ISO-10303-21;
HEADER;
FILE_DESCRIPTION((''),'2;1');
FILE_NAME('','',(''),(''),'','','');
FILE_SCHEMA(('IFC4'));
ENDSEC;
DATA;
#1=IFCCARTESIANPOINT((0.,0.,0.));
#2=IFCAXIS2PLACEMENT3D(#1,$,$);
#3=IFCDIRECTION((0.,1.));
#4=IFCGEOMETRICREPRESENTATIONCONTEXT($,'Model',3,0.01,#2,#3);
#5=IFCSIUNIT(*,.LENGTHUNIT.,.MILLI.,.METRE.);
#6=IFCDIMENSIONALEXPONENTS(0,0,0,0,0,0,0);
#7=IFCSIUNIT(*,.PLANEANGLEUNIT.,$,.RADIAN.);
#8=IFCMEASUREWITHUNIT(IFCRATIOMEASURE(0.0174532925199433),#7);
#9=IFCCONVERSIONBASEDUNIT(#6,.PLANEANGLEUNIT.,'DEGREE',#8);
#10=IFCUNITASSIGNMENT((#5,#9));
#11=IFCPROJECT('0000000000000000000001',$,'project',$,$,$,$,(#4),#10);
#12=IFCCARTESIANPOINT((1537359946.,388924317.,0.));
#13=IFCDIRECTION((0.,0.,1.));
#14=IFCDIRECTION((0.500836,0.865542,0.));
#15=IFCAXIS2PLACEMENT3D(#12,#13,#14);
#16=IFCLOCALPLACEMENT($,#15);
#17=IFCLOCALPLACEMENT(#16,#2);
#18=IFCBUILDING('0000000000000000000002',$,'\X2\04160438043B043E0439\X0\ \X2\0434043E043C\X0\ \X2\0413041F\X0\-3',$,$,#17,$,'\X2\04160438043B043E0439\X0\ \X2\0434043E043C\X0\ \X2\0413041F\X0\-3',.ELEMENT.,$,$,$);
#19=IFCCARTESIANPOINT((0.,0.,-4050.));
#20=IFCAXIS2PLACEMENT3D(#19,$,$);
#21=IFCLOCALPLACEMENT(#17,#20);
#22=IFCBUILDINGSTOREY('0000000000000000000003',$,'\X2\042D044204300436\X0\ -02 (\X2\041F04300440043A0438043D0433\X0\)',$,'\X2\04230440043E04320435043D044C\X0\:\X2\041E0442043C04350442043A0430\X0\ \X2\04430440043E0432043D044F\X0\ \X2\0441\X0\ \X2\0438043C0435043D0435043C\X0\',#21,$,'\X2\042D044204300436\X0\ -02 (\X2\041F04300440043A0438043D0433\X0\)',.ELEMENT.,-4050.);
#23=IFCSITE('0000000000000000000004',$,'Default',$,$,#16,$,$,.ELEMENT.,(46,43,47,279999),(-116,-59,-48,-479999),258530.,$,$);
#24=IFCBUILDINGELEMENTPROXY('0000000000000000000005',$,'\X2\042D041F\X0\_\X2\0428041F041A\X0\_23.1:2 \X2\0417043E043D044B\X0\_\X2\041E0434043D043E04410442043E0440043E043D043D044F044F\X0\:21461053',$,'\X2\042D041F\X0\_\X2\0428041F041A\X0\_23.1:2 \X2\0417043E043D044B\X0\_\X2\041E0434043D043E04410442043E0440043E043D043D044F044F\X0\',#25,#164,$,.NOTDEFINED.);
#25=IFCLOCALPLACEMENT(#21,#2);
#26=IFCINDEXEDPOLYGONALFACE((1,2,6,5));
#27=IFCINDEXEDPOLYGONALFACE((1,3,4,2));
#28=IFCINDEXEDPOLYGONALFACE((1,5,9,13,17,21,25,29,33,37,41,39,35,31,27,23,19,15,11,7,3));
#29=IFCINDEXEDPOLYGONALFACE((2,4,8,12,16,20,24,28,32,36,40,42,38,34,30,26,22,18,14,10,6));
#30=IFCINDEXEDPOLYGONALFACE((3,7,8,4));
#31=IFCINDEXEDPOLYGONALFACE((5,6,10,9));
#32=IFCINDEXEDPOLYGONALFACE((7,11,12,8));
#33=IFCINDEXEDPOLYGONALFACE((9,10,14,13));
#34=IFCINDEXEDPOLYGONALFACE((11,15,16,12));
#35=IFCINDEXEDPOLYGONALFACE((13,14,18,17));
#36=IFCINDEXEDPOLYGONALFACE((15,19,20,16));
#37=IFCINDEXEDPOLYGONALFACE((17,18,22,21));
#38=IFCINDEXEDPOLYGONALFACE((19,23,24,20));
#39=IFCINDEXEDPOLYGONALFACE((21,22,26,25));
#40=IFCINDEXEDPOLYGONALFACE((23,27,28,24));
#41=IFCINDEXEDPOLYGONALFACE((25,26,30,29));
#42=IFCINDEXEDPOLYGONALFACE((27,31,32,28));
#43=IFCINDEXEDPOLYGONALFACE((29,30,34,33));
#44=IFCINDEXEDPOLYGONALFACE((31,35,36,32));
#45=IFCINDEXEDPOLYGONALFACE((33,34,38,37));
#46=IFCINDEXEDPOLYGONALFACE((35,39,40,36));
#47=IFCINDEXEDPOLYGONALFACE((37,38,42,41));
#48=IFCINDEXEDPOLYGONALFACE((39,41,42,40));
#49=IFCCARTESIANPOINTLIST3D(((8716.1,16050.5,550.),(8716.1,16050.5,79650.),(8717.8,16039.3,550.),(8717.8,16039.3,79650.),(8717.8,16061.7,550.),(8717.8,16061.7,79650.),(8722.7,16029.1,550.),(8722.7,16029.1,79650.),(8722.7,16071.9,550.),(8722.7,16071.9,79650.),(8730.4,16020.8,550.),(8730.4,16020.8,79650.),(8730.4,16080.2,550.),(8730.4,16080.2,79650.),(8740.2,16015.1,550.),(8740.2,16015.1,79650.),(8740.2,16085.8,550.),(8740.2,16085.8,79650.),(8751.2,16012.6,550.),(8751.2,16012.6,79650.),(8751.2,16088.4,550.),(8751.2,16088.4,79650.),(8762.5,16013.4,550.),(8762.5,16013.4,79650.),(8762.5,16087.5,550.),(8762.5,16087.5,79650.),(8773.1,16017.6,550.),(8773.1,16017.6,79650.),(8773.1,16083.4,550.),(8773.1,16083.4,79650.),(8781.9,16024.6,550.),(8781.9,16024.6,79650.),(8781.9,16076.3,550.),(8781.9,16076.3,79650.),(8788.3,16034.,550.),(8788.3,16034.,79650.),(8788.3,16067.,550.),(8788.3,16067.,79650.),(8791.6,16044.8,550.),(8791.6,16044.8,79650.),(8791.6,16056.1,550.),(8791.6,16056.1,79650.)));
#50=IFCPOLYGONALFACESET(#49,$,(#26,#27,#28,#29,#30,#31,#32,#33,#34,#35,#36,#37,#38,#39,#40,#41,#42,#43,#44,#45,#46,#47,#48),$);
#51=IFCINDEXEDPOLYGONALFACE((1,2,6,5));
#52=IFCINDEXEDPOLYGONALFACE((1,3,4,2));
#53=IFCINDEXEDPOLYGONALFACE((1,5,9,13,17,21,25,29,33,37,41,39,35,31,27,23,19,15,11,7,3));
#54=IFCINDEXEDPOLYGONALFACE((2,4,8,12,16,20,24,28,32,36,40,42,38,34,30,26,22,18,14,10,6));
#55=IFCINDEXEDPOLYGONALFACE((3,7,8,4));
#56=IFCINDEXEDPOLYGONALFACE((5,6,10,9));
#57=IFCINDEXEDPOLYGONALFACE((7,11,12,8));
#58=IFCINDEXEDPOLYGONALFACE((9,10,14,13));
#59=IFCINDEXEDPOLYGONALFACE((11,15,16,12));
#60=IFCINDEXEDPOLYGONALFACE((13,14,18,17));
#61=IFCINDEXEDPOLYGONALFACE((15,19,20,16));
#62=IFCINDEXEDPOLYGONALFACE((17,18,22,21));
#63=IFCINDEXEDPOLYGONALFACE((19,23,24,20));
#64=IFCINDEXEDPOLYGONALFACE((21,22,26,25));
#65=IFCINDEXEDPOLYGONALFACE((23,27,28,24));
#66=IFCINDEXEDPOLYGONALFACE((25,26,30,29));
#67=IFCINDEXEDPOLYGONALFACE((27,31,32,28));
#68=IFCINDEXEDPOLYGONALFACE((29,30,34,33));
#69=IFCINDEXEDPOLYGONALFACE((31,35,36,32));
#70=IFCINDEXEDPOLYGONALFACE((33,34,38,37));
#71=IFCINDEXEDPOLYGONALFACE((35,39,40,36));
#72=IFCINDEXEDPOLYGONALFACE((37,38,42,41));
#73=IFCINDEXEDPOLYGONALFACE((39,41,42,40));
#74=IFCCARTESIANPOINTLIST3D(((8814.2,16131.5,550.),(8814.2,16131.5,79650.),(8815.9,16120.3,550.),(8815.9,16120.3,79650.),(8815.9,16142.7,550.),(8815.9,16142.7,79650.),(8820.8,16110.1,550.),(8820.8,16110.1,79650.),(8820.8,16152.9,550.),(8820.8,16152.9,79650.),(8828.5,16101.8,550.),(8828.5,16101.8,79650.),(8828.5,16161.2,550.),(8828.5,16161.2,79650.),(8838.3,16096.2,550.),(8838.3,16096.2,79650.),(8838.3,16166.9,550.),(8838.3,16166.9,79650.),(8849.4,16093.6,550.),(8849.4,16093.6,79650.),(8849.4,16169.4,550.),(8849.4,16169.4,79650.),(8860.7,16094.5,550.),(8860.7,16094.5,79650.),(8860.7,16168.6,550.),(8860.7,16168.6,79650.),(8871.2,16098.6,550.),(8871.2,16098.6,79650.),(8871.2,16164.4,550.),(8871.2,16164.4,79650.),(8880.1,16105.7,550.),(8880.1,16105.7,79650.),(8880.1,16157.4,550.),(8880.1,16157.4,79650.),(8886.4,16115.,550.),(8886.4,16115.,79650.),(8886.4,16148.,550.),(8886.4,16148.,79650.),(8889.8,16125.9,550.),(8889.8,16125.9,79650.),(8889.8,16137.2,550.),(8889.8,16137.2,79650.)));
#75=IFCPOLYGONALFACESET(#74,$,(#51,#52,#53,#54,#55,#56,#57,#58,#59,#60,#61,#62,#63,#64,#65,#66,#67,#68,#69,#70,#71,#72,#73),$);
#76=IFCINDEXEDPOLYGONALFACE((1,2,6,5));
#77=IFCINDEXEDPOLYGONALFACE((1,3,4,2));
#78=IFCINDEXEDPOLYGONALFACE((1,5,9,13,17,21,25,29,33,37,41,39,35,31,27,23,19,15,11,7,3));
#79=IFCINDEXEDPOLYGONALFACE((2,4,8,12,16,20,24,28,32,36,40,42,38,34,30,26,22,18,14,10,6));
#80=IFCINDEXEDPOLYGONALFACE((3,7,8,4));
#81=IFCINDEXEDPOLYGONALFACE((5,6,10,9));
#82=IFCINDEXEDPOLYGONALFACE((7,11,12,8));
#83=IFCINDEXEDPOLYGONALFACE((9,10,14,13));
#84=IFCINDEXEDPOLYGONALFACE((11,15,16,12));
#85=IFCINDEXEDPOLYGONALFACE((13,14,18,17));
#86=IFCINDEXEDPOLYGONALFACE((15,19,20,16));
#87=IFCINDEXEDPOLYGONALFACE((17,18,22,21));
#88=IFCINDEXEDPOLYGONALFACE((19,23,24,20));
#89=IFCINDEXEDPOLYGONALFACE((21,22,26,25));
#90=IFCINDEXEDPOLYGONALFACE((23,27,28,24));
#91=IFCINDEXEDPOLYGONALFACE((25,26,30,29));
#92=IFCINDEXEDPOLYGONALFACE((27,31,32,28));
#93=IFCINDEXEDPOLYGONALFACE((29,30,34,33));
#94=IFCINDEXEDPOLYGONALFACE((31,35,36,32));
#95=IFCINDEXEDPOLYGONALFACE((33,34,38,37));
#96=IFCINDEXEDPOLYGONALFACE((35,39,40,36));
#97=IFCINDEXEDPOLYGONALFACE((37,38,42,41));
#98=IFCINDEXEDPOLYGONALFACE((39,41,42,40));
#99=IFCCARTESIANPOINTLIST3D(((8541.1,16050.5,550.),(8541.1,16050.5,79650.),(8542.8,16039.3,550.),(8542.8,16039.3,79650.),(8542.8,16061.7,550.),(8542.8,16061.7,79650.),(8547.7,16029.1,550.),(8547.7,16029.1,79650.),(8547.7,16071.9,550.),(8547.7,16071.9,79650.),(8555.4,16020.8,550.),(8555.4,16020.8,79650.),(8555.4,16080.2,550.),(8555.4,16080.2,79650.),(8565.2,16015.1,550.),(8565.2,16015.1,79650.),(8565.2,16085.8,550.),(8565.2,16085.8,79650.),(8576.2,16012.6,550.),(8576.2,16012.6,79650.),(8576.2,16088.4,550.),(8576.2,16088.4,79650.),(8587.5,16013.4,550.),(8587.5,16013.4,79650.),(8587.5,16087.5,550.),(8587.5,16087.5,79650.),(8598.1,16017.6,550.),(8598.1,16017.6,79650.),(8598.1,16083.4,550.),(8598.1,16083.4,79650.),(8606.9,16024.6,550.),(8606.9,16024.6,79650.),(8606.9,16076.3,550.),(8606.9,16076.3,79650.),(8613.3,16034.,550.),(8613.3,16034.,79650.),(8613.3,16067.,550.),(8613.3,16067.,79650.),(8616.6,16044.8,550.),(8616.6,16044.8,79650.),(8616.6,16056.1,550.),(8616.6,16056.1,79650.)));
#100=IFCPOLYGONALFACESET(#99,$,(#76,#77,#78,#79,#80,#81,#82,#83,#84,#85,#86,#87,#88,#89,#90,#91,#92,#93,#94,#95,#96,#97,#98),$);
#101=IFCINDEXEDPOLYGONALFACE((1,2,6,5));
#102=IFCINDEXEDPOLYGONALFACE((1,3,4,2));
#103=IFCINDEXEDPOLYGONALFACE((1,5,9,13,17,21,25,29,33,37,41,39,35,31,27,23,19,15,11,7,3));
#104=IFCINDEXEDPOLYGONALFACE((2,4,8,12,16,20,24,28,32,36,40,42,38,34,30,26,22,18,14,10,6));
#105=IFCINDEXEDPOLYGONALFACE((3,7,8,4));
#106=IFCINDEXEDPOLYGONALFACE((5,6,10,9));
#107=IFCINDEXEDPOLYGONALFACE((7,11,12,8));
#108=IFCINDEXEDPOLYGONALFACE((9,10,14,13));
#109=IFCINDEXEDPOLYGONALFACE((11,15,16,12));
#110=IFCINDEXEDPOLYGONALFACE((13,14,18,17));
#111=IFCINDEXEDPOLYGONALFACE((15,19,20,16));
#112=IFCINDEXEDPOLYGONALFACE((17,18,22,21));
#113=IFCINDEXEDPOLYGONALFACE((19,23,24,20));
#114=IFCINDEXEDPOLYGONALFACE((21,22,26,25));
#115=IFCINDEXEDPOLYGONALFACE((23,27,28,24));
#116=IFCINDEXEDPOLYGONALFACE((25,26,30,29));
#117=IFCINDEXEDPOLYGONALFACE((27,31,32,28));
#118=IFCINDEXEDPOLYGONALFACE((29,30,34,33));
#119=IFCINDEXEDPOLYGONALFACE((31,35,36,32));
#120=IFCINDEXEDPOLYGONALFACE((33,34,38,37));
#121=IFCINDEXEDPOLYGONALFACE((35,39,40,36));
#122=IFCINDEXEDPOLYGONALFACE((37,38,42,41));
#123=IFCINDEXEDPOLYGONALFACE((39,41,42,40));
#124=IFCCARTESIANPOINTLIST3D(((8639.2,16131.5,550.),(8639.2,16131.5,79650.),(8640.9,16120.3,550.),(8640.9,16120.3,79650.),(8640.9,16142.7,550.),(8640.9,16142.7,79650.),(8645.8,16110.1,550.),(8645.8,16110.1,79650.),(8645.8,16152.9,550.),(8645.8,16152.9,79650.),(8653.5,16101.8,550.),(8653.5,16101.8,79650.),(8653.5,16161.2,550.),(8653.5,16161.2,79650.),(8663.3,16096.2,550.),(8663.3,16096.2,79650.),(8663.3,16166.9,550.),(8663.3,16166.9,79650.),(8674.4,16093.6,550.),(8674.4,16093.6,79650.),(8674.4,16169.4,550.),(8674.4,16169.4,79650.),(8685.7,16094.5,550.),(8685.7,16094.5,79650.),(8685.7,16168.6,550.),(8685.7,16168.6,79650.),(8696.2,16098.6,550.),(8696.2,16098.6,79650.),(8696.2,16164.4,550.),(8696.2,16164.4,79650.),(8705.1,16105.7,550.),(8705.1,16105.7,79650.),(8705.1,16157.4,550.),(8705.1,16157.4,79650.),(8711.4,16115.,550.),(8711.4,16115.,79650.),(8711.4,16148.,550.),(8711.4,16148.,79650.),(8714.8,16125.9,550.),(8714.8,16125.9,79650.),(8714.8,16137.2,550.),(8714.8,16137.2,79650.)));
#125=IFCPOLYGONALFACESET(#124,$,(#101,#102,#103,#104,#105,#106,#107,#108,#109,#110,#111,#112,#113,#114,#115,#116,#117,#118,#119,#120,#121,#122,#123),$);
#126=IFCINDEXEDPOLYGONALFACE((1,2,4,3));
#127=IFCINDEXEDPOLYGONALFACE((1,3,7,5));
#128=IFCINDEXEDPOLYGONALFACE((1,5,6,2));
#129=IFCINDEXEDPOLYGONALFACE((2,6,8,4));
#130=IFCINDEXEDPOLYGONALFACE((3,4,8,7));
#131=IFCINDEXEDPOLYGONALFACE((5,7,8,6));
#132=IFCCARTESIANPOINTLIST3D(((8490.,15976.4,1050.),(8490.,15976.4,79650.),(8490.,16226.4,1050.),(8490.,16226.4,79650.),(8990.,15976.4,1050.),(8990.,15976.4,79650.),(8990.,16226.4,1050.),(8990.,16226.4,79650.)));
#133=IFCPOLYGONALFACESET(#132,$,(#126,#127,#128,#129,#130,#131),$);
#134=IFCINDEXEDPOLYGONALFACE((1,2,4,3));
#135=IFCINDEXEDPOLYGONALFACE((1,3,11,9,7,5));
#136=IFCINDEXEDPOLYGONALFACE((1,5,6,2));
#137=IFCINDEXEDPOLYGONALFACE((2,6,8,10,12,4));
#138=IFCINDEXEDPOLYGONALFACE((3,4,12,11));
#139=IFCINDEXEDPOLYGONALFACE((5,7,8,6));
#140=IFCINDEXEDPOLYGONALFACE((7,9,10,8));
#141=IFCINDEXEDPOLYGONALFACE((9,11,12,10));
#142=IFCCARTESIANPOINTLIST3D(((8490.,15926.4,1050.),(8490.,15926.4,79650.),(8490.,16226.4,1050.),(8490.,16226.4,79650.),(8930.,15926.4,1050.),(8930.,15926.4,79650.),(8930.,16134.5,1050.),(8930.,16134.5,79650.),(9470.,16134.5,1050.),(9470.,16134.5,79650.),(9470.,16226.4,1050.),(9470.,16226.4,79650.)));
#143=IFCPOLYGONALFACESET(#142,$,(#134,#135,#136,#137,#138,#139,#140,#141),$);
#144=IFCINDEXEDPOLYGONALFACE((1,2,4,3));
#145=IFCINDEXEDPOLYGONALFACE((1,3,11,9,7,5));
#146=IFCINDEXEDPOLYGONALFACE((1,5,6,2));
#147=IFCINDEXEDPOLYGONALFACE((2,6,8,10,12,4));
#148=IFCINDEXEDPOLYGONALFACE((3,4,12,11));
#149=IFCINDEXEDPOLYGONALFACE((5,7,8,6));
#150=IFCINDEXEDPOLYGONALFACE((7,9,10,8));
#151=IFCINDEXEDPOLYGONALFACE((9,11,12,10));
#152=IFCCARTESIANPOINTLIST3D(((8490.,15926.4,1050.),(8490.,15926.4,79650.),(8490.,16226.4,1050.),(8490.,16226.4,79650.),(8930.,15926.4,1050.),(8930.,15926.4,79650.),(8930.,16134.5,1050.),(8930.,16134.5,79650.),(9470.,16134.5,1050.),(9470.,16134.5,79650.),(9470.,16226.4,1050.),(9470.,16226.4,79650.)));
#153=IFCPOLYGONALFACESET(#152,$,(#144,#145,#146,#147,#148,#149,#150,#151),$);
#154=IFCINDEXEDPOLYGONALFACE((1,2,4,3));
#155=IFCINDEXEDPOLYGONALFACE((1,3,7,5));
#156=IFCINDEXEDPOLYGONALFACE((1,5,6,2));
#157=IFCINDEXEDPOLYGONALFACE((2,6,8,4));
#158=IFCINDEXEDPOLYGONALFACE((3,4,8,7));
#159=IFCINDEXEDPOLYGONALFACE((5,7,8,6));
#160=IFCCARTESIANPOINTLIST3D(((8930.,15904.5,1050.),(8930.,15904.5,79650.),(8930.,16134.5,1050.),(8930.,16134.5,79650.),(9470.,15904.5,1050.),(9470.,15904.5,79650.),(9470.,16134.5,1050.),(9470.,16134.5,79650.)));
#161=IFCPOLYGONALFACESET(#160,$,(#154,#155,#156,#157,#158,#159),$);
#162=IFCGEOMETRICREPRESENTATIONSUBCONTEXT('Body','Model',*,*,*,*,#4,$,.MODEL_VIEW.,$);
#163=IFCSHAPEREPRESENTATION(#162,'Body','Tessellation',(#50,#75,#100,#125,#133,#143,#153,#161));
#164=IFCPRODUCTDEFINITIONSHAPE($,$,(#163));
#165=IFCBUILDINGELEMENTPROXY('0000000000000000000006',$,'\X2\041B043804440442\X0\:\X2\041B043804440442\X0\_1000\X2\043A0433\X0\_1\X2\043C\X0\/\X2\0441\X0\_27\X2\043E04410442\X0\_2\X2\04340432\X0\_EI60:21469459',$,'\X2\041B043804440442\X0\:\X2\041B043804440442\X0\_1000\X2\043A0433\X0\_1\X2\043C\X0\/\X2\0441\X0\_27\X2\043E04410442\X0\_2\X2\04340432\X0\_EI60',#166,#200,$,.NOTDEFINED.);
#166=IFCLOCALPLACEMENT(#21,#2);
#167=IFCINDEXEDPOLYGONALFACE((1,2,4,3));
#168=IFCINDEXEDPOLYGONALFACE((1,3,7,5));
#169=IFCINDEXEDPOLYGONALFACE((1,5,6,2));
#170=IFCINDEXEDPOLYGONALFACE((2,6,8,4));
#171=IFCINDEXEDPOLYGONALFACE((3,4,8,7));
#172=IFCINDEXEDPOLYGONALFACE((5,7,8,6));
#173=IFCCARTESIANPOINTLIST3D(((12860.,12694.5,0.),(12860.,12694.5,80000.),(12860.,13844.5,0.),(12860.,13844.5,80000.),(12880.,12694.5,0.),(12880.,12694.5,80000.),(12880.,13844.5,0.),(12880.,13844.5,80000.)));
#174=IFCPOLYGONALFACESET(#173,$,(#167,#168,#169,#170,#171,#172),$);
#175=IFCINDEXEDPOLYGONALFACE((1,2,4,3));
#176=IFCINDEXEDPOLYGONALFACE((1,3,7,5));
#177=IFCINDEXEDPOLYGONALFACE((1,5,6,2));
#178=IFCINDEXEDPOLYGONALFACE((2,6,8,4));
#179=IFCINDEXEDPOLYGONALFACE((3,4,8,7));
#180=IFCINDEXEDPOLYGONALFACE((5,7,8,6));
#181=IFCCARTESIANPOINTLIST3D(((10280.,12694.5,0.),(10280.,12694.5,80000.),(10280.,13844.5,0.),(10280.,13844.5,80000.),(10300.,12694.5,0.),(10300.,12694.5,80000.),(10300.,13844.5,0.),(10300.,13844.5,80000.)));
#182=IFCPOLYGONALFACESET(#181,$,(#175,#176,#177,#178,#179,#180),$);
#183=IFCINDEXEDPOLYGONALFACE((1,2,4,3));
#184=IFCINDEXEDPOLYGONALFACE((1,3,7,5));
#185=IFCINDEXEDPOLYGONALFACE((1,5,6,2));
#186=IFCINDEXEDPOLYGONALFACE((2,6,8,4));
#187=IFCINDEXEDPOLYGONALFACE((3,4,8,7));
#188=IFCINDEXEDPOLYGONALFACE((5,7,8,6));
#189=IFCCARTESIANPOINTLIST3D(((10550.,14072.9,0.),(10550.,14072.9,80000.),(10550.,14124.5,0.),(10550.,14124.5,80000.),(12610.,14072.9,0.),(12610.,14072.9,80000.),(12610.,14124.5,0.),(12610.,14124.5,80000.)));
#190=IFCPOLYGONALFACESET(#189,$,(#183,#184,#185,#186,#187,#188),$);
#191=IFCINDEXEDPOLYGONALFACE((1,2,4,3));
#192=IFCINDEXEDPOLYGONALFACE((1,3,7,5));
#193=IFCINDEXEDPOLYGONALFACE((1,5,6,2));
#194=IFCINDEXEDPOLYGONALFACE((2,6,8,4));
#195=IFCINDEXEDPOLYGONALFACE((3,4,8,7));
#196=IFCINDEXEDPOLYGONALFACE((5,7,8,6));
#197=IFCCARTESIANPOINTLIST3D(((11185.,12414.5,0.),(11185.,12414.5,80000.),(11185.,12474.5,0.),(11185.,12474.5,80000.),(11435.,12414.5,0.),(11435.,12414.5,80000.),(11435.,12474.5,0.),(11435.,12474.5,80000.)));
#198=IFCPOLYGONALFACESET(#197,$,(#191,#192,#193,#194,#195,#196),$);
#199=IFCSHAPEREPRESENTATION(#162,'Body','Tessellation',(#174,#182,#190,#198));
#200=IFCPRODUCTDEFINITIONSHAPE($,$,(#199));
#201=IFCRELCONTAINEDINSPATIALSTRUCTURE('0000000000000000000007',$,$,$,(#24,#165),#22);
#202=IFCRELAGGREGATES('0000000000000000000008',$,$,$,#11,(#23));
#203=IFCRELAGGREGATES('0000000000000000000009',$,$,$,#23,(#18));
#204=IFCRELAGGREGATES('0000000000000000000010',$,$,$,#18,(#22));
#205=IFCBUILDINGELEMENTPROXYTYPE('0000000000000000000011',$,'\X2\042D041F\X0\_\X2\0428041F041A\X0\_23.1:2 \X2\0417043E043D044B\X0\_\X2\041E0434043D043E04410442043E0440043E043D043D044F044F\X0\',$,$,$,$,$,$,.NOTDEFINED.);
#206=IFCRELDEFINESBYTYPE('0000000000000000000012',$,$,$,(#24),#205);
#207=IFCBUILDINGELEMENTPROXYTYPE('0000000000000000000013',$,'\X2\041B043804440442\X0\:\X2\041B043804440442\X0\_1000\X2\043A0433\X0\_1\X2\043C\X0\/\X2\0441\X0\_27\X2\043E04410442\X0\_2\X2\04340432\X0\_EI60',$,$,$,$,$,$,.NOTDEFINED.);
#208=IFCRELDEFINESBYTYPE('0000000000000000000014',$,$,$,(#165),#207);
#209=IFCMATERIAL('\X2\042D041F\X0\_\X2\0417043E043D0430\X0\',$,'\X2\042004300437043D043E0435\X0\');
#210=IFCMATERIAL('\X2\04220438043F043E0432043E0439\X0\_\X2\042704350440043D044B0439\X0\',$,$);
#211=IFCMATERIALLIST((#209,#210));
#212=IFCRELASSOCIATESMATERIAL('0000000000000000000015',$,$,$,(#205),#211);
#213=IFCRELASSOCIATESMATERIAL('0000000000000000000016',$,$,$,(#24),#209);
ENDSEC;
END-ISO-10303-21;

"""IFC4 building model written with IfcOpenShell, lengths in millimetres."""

from ifc_helpers import new_model, entity, si_unit, converted_unit, direction, frame, frame_2d, origin, origin_2d_with_axis, place, context, subcontext, project, spatial, polyline, rectangle, circle, outline, extrude, source, transform, mapped, material, material_list, type_object, type_shapes, element, save


model = new_model("IFC4")

# Units and contexts
model_context = context("Model", 3, precision=0.01, world=origin(), true_north=direction((0.0, 1.0)))
body_context = subcontext(model_context, "Body", "Model", "MODEL_VIEW")
ifc_project = project(units=[si_unit("LENGTHUNIT", "METRE", prefix="MILLI"), converted_unit("PLANEANGLEUNIT", "DEGREE", entity("IfcRatioMeasure", 0.0174532925199433), si_unit("PLANEANGLEUNIT", "RADIAN"), dimensions=[0, 0, 0, 0, 0, 0, 0])], contexts=[model_context])

# Site, building, storey
site_placement = place(None, frame((1537359946.0, 388924317.0, 0.0), z_axis=(0.0, 0.0, 1.0), x_axis=(0.500836, 0.865542, 0.0)))
site = spatial("IfcSite", under=ifc_project, at=site_placement, Name="Default", CompositionType="ELEMENT", RefLatitude=(46, 43, 47, 279999), RefLongitude=(-116, -59, -48, -479999), RefElevation=258530.0)
building_placement = place(site_placement, origin())
building = spatial("IfcBuilding", under=site, at=building_placement, Name="Жилой дом ГП-3", LongName="Жилой дом ГП-3", CompositionType="ELEMENT")
storey_placement = place(building_placement, frame((0.0, 0.0, -4050.0)))
storey = spatial("IfcBuildingStorey", under=building, at=storey_placement, Name="Этаж -02 (Паркинг)", ObjectType="Уровень:Отметка уровня с именем", LongName="Этаж -02 (Паркинг)", CompositionType="ELEMENT", Elevation=-4050.0)

# Building element proxies
ifc_material_1 = material(Name="Типовой_Черный")
ifc_material_2 = material(Name="ЭП_Зона", Category="Разное")
ifc_material_list_1 = material_list([ifc_material_2, ifc_material_1])
building_element_proxy_type_1 = type_object("IfcBuildingElementProxyType", Name="ЭП_ШПК_23.1:2 Зоны_Односторонняя", PredefinedType="NOTDEFINED", material=ifc_material_list_1)
shared_shape_1 = source(origin(), body_context, "Body", "SweptSolid", [
    extrude(circle(Radius=38.0, at=frame_2d((0.0, 0.0), x_axis=(1.0, 0.0))), frame((264.1, -176.0, -3500.0), z_axis=(0.0, 0.0, 1.0), x_axis=(-1.0, 0.0, 0.0)), (0.0, 0.0, 1.0), 79100.0),
    extrude(circle(Radius=38.0, at=frame_2d((0.0, 0.0), x_axis=(1.0, 0.0))), frame((362.2, -94.9, -3500.0), z_axis=(0.0, 0.0, 1.0), x_axis=(-1.0, 0.0, 0.0)), (0.0, 0.0, 1.0), 79100.0),
    extrude(circle(Radius=38.0, at=frame_2d((0.0, 0.0), x_axis=(1.0, 0.0))), frame((89.1, -176.0, -3500.0), z_axis=(0.0, 0.0, 1.0), x_axis=(-1.0, 0.0, 0.0)), (0.0, 0.0, 1.0), 79100.0),
    extrude(circle(Radius=38.0, at=frame_2d((0.0, 0.0), x_axis=(1.0, 0.0))), frame((187.2, -94.9, -3500.0), z_axis=(0.0, 0.0, 1.0), x_axis=(-1.0, 0.0, 0.0)), (0.0, 0.0, 1.0), 79100.0),
    extrude(rectangle(XDim=500.0, YDim=250.0, at=origin_2d_with_axis()), frame((250.0, -125.0, -3000.0), z_axis=(0.0, 0.0, 1.0), x_axis=(-1.0, 0.0, 0.0)), (0.0, 0.0, 1.0), 78600.0),
    extrude(outline(polyline([(-506.7, -130.6), (473.3, -130.6), (473.3, 169.4), (33.3, 169.4), (33.3, -38.7), (-506.7, -38.7), (-506.7, -130.6)])), frame((473.3, -130.6, -3000.0), z_axis=(0.0, 0.0, 1.0), x_axis=(-1.0, 0.0, 0.0)), (0.0, 0.0, 1.0), 78600.0),
    extrude(outline(polyline([(-506.7, -130.6), (473.3, -130.6), (473.3, 169.4), (33.3, 169.4), (33.3, -38.7), (-506.7, -38.7), (-506.7, -130.6)])), frame((473.3, -130.6, -3000.0), z_axis=(0.0, 0.0, 1.0), x_axis=(-1.0, 0.0, 0.0)), (0.0, 0.0, 1.0), 78600.0),
    extrude(rectangle(XDim=230.0, YDim=540.0, at=frame_2d((0.0, 0.0), x_axis=(1.0, 0.0))), frame((710.0, -206.9, -3000.0), z_axis=(0.0, 0.0, 1.0), x_axis=(0.0, 1.0, 0.0)), (0.0, 0.0, 1.0), 78600.0),
])
type_shapes(building_element_proxy_type_1, [shared_shape_1])
proxy_1_placement = place(storey_placement, frame((8490.0, 16226.4, 4050.0)))
element("IfcBuildingElementProxy", 1, at=proxy_1_placement, inside=storey, type_object=building_element_proxy_type_1, material=ifc_material_2, Name="ЭП_ШПК_23.1:2 Зоны_Односторонняя:21461053", ObjectType="ЭП_ШПК_23.1:2 Зоны_Односторонняя", PredefinedType="NOTDEFINED", context=body_context, shape_type="MappedRepresentation", body=[
    mapped(shared_shape_1, transform((0.0, 0.0, 0.0), scale=1.0)),
])
building_element_proxy_type_2 = type_object("IfcBuildingElementProxyType", Name="Лифт:Лифт_1000кг_1м/с_27ост_2дв_EI60", PredefinedType="NOTDEFINED")
shared_shape_2 = source(origin(), body_context, "Body", "SweptSolid", [
    extrude(rectangle(XDim=1150.0, YDim=20.0, at=frame_2d((0.0, 0.0), x_axis=(1.0, 0.0))), frame((0.0, -1290.0, 0.0), z_axis=(0.0, 0.0, 1.0), x_axis=(-1.0, 0.0, 0.0)), (0.0, 0.0, 1.0), 80000.0),
    extrude(rectangle(XDim=20.0, YDim=1150.0, at=frame_2d((0.0, 0.0), x_axis=(1.0, 0.0))), frame((0.0, 1290.0, 0.0), z_axis=(0.0, 0.0, 1.0), x_axis=(0.0, 1.0, 0.0)), (0.0, 0.0, 1.0), 80000.0),
    extrude(rectangle(XDim=51.7, YDim=2060.0, at=frame_2d((0.0, 0.0), x_axis=(1.0, 0.0))), frame((829.2, 0.0, 0.0), z_axis=(0.0, 0.0, 1.0), x_axis=(-1.0, 0.0, 0.0)), (0.0, 0.0, 1.0), 80000.0),
    extrude(rectangle(XDim=60.0, YDim=250.0, at=origin_2d_with_axis()), frame((-825.0, 270.0, 0.0), z_axis=(0.0, 0.0, 1.0), x_axis=(-1.0, 0.0, 0.0)), (0.0, 0.0, 1.0), 80000.0),
])
type_shapes(building_element_proxy_type_2, [shared_shape_2])
for number, where, z_axis, x_axis, name in (
    (2, (11580.0, 13269.5, 0.0), (0.0, 0.0, 1.0), (0.0, 1.0, 0.0), "Лифт:Лифт_1000кг_1м/с_27ост_2дв_EI60:21469459"),
):
    element("IfcBuildingElementProxy", number, at=place(storey_placement, frame(where, z_axis=z_axis, x_axis=x_axis)), inside=storey, type_object=building_element_proxy_type_2, Name=name, ObjectType="Лифт:Лифт_1000кг_1м/с_27ост_2дв_EI60", PredefinedType="NOTDEFINED", context=body_context, shape_type="MappedRepresentation", body=[
        mapped(shared_shape_2, transform((0.0, 0.0, 0.0), scale=1.0)),
    ])

save(model, "model.ifc")
